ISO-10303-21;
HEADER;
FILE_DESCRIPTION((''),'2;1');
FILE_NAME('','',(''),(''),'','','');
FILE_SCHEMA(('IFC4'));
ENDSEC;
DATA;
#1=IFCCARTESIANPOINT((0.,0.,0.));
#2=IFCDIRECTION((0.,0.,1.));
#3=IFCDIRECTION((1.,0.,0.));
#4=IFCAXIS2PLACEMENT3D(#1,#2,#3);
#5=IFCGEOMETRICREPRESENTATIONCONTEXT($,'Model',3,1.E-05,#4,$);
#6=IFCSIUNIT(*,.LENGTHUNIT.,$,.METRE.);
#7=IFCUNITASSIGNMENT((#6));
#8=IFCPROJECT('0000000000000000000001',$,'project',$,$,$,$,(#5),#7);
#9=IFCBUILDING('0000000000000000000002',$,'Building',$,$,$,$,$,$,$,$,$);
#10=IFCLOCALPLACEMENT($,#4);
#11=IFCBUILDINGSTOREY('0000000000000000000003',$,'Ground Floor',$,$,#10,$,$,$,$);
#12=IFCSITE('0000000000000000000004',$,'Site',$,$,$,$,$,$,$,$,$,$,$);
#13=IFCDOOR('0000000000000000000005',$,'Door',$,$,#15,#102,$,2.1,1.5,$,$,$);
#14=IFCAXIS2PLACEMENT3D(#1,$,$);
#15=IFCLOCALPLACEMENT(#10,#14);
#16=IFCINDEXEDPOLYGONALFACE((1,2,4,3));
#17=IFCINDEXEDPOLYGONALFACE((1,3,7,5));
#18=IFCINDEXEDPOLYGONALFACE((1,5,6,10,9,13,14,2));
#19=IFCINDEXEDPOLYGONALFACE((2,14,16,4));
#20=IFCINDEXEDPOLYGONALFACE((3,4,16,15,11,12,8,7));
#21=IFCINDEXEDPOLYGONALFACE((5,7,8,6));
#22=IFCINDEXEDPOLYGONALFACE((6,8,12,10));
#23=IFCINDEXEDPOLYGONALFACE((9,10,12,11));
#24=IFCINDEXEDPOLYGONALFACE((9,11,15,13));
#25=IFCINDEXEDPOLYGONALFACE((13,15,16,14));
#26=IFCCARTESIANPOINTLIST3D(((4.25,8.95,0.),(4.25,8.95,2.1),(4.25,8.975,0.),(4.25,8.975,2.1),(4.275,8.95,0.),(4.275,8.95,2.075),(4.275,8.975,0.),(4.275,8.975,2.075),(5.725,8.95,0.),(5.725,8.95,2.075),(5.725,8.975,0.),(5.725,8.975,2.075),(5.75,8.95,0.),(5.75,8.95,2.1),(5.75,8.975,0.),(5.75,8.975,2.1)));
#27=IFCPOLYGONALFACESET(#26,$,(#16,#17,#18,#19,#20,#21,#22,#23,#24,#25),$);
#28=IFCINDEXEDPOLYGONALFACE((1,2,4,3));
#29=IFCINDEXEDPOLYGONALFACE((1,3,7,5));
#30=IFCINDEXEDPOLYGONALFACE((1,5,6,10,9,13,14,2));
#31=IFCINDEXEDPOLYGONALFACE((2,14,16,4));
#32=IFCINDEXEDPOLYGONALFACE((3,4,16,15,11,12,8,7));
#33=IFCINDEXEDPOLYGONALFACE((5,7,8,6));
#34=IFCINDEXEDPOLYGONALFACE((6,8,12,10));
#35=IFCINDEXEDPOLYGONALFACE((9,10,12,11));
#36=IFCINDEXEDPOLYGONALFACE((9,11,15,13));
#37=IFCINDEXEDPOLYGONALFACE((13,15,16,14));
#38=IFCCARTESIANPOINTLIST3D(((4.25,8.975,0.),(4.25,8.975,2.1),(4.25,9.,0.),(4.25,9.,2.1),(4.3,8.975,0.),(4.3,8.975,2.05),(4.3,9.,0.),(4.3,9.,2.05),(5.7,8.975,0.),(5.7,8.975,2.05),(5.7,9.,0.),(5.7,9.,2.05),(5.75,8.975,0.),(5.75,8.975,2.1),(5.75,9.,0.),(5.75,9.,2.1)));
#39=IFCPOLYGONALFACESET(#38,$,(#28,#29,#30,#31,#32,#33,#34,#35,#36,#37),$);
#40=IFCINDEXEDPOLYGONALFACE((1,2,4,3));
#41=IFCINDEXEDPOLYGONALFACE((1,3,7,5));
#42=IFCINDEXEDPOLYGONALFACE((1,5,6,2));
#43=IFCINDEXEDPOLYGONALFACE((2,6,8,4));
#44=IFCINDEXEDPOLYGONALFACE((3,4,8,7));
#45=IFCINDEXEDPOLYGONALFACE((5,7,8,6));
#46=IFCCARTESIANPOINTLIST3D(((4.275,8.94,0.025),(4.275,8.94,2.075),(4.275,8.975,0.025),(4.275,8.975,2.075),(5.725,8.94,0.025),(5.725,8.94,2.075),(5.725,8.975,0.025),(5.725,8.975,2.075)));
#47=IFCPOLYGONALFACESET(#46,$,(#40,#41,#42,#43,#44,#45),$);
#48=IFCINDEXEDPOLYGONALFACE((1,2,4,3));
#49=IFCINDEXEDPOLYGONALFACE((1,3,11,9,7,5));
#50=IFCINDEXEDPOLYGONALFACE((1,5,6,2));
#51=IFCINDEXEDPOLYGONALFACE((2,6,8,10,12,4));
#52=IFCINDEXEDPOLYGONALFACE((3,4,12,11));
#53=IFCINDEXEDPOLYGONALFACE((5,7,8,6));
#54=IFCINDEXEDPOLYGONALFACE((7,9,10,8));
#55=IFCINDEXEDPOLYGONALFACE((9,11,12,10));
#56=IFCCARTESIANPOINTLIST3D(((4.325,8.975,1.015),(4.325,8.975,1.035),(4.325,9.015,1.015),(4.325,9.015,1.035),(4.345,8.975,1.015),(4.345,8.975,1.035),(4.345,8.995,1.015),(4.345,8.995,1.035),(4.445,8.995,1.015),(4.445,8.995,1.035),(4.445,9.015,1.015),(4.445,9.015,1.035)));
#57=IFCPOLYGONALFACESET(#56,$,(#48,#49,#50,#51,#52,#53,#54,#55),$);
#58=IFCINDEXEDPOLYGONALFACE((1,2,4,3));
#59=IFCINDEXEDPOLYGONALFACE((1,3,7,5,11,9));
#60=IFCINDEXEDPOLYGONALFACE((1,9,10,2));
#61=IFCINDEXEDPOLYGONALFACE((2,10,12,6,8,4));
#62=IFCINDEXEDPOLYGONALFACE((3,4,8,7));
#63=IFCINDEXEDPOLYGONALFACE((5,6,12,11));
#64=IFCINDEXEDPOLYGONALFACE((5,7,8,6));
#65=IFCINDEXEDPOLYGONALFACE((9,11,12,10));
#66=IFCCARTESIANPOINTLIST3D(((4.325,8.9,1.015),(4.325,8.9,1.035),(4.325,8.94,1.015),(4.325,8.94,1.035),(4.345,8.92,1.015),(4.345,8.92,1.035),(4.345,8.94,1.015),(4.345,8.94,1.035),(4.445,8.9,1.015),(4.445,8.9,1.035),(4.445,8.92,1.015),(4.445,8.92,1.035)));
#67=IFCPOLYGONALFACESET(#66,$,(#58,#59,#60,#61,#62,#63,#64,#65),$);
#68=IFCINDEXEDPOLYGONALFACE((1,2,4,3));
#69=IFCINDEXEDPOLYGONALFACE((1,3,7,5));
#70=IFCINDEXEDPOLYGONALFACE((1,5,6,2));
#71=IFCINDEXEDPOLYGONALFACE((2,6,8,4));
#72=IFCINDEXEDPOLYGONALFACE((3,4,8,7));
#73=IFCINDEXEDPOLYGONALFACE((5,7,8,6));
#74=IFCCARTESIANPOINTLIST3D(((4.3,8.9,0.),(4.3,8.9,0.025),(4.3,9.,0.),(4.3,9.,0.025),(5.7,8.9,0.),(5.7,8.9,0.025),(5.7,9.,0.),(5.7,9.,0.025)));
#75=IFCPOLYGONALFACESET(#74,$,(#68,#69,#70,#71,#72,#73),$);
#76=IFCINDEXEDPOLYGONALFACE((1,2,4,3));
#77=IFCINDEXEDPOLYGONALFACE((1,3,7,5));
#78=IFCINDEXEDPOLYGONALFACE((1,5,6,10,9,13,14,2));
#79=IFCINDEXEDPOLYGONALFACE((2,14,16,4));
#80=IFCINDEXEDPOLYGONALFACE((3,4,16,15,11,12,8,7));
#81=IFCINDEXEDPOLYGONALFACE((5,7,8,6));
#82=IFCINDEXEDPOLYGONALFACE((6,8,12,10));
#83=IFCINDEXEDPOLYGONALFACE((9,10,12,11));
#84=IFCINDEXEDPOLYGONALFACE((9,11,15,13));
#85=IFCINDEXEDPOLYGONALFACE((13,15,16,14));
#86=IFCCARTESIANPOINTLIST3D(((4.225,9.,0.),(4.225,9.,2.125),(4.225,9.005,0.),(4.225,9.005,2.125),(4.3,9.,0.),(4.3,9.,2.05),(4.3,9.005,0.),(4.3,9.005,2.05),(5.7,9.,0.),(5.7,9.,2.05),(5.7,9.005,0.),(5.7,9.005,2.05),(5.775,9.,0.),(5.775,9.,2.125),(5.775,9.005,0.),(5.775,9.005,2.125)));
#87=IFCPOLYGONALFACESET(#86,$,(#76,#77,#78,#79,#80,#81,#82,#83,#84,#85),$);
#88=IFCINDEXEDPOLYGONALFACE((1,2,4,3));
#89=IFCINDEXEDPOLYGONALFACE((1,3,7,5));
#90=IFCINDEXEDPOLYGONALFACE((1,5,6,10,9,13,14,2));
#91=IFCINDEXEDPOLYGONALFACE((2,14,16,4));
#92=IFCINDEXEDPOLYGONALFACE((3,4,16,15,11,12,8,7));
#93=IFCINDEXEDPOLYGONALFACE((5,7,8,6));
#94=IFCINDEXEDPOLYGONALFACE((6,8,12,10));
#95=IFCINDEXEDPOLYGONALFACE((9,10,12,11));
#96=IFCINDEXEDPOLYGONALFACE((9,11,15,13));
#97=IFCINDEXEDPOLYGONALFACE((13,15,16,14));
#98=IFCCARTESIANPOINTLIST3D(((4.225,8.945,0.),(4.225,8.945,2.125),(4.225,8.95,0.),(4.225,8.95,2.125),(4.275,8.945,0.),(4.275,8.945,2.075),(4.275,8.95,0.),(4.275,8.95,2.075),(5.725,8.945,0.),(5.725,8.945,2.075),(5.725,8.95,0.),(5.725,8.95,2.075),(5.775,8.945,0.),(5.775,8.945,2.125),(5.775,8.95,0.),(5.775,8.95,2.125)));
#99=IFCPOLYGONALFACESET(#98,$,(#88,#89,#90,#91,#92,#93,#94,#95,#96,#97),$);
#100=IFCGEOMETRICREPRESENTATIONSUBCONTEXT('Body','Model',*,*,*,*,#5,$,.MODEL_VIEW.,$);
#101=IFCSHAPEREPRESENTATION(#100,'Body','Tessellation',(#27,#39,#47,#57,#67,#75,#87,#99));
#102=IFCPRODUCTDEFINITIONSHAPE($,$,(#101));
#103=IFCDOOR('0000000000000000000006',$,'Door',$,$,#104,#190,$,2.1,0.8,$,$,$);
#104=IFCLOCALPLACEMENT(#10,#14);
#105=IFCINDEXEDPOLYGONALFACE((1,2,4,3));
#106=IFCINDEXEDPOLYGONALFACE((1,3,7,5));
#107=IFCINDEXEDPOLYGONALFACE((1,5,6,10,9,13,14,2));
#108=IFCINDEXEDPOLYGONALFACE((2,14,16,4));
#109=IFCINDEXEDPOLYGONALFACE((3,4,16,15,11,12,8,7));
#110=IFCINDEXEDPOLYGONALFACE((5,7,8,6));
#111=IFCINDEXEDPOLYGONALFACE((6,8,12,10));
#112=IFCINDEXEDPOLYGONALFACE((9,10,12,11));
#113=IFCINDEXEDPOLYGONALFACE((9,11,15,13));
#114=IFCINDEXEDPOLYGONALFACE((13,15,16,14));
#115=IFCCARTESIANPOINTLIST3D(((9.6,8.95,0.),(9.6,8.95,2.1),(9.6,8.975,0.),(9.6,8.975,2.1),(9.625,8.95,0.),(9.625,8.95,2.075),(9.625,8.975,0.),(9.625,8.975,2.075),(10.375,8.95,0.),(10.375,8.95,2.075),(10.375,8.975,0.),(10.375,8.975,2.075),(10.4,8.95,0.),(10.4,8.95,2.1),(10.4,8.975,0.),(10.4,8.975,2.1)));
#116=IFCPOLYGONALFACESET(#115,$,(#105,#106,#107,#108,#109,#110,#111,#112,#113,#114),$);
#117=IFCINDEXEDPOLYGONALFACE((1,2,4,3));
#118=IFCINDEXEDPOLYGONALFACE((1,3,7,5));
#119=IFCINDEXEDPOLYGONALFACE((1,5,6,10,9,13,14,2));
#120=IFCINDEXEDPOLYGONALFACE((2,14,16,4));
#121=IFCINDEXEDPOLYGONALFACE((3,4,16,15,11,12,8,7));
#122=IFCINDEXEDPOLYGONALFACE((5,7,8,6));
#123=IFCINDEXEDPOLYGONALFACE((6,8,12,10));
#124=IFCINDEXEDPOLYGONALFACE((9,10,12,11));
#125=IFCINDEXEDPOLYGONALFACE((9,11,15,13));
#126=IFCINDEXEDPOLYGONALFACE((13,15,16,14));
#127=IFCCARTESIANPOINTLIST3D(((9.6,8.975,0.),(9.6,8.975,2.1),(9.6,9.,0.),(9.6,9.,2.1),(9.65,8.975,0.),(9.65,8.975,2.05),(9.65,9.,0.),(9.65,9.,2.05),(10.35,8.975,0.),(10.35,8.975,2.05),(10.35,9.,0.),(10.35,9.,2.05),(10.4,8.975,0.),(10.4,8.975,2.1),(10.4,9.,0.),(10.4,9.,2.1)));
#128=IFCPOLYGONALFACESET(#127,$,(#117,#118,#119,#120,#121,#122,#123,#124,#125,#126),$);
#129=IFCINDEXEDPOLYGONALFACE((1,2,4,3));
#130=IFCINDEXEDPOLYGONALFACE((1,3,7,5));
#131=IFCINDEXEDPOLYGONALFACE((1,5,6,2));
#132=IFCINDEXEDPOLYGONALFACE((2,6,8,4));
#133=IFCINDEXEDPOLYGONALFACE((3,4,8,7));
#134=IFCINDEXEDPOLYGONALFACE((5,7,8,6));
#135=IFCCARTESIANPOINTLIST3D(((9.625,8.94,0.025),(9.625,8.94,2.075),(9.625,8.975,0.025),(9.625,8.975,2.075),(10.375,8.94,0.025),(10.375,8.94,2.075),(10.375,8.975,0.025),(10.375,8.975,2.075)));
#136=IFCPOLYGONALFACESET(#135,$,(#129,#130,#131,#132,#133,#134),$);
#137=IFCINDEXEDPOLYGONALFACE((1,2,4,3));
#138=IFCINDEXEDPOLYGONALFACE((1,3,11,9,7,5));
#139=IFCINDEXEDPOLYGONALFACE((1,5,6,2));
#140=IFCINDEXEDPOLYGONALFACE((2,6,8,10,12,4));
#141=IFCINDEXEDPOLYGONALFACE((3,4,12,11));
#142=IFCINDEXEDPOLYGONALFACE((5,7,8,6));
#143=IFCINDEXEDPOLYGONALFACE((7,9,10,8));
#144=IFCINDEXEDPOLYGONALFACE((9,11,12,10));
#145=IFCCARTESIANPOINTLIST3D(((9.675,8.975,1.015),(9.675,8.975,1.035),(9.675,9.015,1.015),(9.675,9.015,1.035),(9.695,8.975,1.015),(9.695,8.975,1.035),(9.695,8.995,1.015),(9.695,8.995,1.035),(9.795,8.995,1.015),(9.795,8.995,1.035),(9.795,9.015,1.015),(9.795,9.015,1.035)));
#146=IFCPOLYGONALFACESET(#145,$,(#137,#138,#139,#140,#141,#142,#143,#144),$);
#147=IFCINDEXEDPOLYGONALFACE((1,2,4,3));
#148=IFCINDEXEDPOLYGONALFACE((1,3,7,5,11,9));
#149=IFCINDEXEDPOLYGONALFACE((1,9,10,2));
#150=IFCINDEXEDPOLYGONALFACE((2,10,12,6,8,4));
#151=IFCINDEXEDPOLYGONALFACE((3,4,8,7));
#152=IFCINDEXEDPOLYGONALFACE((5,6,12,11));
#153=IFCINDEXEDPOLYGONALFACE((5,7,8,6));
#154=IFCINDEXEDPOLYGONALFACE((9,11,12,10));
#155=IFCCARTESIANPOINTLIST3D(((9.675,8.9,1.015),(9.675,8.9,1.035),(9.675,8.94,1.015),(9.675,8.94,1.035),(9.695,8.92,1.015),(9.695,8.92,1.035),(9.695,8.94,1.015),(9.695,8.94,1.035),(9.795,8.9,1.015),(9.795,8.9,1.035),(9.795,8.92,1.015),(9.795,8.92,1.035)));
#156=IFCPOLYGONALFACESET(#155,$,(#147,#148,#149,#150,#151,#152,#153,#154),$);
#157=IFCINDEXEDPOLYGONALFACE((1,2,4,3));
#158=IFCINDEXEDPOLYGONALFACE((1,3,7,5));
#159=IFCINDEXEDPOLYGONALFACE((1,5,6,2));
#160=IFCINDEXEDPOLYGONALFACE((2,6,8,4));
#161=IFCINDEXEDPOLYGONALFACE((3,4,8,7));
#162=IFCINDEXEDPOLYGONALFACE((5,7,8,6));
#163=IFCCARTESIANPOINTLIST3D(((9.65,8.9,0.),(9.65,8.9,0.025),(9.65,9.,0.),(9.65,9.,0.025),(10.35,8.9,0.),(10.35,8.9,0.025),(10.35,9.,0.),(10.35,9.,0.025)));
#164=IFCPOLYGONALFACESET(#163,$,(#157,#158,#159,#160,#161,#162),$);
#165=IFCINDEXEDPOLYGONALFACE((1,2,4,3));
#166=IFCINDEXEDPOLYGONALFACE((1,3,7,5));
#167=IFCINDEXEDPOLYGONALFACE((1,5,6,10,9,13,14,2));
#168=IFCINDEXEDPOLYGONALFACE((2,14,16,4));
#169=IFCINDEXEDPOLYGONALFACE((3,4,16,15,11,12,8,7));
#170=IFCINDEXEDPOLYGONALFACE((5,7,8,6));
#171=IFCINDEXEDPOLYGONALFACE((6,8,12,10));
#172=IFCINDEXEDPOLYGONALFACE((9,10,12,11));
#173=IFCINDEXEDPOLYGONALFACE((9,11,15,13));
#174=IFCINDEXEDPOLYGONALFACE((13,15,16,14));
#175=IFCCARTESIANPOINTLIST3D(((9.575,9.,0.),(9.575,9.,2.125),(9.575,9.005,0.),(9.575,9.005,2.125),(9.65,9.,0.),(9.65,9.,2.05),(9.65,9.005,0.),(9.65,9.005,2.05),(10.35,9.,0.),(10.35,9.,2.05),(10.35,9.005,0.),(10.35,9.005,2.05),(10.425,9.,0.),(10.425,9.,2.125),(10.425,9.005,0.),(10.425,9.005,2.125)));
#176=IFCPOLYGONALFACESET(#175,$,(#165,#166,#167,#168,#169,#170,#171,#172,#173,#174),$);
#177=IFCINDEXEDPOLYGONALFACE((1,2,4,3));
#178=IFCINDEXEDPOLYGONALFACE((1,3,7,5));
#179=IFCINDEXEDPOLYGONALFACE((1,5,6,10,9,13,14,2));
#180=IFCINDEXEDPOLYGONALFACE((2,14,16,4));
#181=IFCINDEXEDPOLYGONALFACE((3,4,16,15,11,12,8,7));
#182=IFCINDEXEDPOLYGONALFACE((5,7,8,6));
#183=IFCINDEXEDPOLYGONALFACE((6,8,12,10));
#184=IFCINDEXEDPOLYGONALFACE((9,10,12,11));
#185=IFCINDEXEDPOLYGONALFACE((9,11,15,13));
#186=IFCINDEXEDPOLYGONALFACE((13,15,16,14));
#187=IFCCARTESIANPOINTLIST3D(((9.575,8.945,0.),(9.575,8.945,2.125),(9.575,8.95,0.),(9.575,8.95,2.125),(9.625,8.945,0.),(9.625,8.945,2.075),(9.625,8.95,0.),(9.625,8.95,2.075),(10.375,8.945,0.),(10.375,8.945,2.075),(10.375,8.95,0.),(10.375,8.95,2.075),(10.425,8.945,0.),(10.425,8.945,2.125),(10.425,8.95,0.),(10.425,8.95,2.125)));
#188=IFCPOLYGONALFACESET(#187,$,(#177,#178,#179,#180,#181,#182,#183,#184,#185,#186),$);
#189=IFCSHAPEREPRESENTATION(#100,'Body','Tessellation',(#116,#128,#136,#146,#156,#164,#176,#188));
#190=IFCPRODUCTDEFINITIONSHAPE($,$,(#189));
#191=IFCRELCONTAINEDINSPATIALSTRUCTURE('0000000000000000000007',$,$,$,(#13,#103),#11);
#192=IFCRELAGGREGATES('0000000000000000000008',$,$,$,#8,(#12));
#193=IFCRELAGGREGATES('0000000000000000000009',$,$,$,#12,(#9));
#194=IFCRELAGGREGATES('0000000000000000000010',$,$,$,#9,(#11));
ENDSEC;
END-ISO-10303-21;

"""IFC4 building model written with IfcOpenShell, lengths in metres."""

from ifc_helpers import new_model, si_unit, frame, origin_with_axes, place, context, subcontext, project, spatial, line, indexed_curve, outline, extrude, element, save


model = new_model("IFC4")

# Units and contexts
model_context = context("Model", 3, precision=1e-05, world=origin_with_axes())
body_context = subcontext(model_context, "Body", "Model", "MODEL_VIEW")
ifc_project = project(units=[si_unit("LENGTHUNIT", "METRE")], contexts=[model_context])

# Site, building, storey
site = spatial("IfcSite", under=ifc_project, Name="Site")
building = spatial("IfcBuilding", under=site, Name="Building")
storey_placement = place(None, origin_with_axes())
storey = spatial("IfcBuildingStorey", under=building, at=storey_placement, Name="Ground Floor")

# Doors
door_1_placement = place(storey_placement, frame((5.75, 9.0, 0.0), z_axis=(0.0, 0.0, 1.0), x_axis=(-1.0, 0.0, 0.0)))
element("IfcDoor", 1, at=door_1_placement, inside=storey, Name="Door", OverallHeight=2.1, OverallWidth=1.5, context=body_context, shape_type="SweptSolid", body=[
    extrude(outline(indexed_curve([(0.0, 0.0), (0.0, 2.1), (1.5, 2.1), (1.5, 0.0), (1.475, 0.0), (1.475, 2.075), (0.025, 2.075), (0.025, 0.0)], segments=[line(1, 2, 3, 4, 5, 6, 7, 8, 1)])), frame((0.0, 0.025, 0.0), z_axis=(0.0, -1.0, 0.0), x_axis=(1.0, 0.0, 0.0)), (0.0, 0.0, -1.0), 0.025),
    extrude(outline(indexed_curve([(0.0, 0.0), (0.0, 2.1), (1.5, 2.1), (1.5, 0.0), (1.45, 0.0), (1.45, 2.05), (0.05, 2.05), (0.05, 0.0)], segments=[line(1, 2, 3, 4, 5, 6, 7, 8, 1)])), frame((0.0, 0.0, 0.0), z_axis=(0.0, -1.0, 0.0), x_axis=(1.0, 0.0, 0.0)), (0.0, 0.0, -1.0), 0.025),
    extrude(outline(indexed_curve([(0.0, 0.0), (1.45, 0.0), (1.45, 0.035), (0.0, 0.035)], segments=[line(1, 2, 3, 4, 1)])), frame((0.025, 0.025, 0.025), z_axis=(0.0, 0.0, 1.0), x_axis=(1.0, 0.0, 0.0)), (0.0, 0.0, 1.0), 2.05),
    extrude(outline(indexed_curve([(0.0, 0.0), (0.0, -0.04), (-0.12, -0.04), (-0.12, -0.02), (-0.02, -0.02), (-0.02, 0.0)], segments=[line(1, 2, 3, 4, 5, 6, 1)])), frame((1.425, 0.025, 1.015), z_axis=(0.0, 0.0, 1.0), x_axis=(1.0, 0.0, 0.0)), (0.0, 0.0, 1.0), 0.02),
    extrude(outline(indexed_curve([(0.0, 0.0), (0.0, 0.04), (-0.12, 0.04), (-0.12, 0.02), (-0.02, 0.02), (-0.02, 0.0)], segments=[line(1, 2, 3, 4, 5, 6, 1)])), frame((1.425, 0.06, 1.015), z_axis=(0.0, 0.0, 1.0), x_axis=(1.0, 0.0, 0.0)), (0.0, 0.0, 1.0), 0.02),
    extrude(outline(indexed_curve([(0.0, 0.0), (1.4, 0.0), (1.4, 0.1), (0.0, 0.1)], segments=[line(1, 2, 3, 4, 1)])), frame((0.05, 0.0, 0.0), z_axis=(0.0, 0.0, 1.0), x_axis=(1.0, 0.0, 0.0)), (0.0, 0.0, 1.0), 0.025),
    extrude(outline(indexed_curve([(0.0, 0.0), (0.0, 2.125), (1.55, 2.125), (1.55, 0.0), (1.475, 0.0), (1.475, 2.05), (0.075, 2.05), (0.075, 0.0)], segments=[line(1, 2, 3, 4, 5, 6, 7, 8, 1)])), frame((-0.025, -0.005, 0.0), z_axis=(0.0, -1.0, 0.0), x_axis=(1.0, 0.0, 0.0)), (0.0, 0.0, -1.0), 0.005),
    extrude(outline(indexed_curve([(0.0, 0.0), (0.0, 2.125), (1.55, 2.125), (1.55, 0.0), (1.5, 0.0), (1.5, 2.075), (0.05, 2.075), (0.05, 0.0)], segments=[line(1, 2, 3, 4, 5, 6, 7, 8, 1)])), frame((-0.025, 0.05, 0.0), z_axis=(0.0, -1.0, 0.0), x_axis=(1.0, 0.0, 0.0)), (0.0, 0.0, -1.0), 0.005),
])
door_2_placement = place(storey_placement, frame((10.4, 9.0, 0.0), z_axis=(0.0, 0.0, 1.0), x_axis=(-1.0, 0.0, 0.0)))
element("IfcDoor", 2, at=door_2_placement, inside=storey, Name="Door", OverallHeight=2.1, OverallWidth=0.8, context=body_context, shape_type="SweptSolid", body=[
    extrude(outline(indexed_curve([(0.0, 0.0), (0.0, 2.1), (0.8, 2.1), (0.8, 0.0), (0.775, 0.0), (0.775, 2.075), (0.025, 2.075), (0.025, 0.0)], segments=[line(1, 2, 3, 4, 5, 6, 7, 8, 1)])), frame((0.0, 0.025, 0.0), z_axis=(0.0, -1.0, 0.0), x_axis=(1.0, 0.0, 0.0)), (0.0, 0.0, -1.0), 0.025),
    extrude(outline(indexed_curve([(0.0, 0.0), (0.0, 2.1), (0.8, 2.1), (0.8, 0.0), (0.75, 0.0), (0.75, 2.05), (0.05, 2.05), (0.05, 0.0)], segments=[line(1, 2, 3, 4, 5, 6, 7, 8, 1)])), frame((0.0, 0.0, 0.0), z_axis=(0.0, -1.0, 0.0), x_axis=(1.0, 0.0, 0.0)), (0.0, 0.0, -1.0), 0.025),
    extrude(outline(indexed_curve([(0.0, 0.0), (0.75, 0.0), (0.75, 0.035), (0.0, 0.035)], segments=[line(1, 2, 3, 4, 1)])), frame((0.025, 0.025, 0.025), z_axis=(0.0, 0.0, 1.0), x_axis=(1.0, 0.0, 0.0)), (0.0, 0.0, 1.0), 2.05),
    extrude(outline(indexed_curve([(0.0, 0.0), (0.0, -0.04), (-0.12, -0.04), (-0.12, -0.02), (-0.02, -0.02), (-0.02, 0.0)], segments=[line(1, 2, 3, 4, 5, 6, 1)])), frame((0.725, 0.025, 1.015), z_axis=(0.0, 0.0, 1.0), x_axis=(1.0, 0.0, 0.0)), (0.0, 0.0, 1.0), 0.02),
    extrude(outline(indexed_curve([(0.0, 0.0), (0.0, 0.04), (-0.12, 0.04), (-0.12, 0.02), (-0.02, 0.02), (-0.02, 0.0)], segments=[line(1, 2, 3, 4, 5, 6, 1)])), frame((0.725, 0.06, 1.015), z_axis=(0.0, 0.0, 1.0), x_axis=(1.0, 0.0, 0.0)), (0.0, 0.0, 1.0), 0.02),
    extrude(outline(indexed_curve([(0.0, 0.0), (0.7, 0.0), (0.7, 0.1), (0.0, 0.1)], segments=[line(1, 2, 3, 4, 1)])), frame((0.05, 0.0, 0.0), z_axis=(0.0, 0.0, 1.0), x_axis=(1.0, 0.0, 0.0)), (0.0, 0.0, 1.0), 0.025),
    extrude(outline(indexed_curve([(0.0, 0.0), (0.0, 2.125), (0.85, 2.125), (0.85, 0.0), (0.775, 0.0), (0.775, 2.05), (0.075, 2.05), (0.075, 0.0)], segments=[line(1, 2, 3, 4, 5, 6, 7, 8, 1)])), frame((-0.025, -0.005, 0.0), z_axis=(0.0, -1.0, 0.0), x_axis=(1.0, 0.0, 0.0)), (0.0, 0.0, -1.0), 0.005),
    extrude(outline(indexed_curve([(0.0, 0.0), (0.0, 2.125), (0.85, 2.125), (0.85, 0.0), (0.8, 0.0), (0.8, 2.075), (0.05, 2.075), (0.05, 0.0)], segments=[line(1, 2, 3, 4, 5, 6, 7, 8, 1)])), frame((-0.025, 0.05, 0.0), z_axis=(0.0, -1.0, 0.0), x_axis=(1.0, 0.0, 0.0)), (0.0, 0.0, -1.0), 0.005),
])

save(model, "model.ifc")
